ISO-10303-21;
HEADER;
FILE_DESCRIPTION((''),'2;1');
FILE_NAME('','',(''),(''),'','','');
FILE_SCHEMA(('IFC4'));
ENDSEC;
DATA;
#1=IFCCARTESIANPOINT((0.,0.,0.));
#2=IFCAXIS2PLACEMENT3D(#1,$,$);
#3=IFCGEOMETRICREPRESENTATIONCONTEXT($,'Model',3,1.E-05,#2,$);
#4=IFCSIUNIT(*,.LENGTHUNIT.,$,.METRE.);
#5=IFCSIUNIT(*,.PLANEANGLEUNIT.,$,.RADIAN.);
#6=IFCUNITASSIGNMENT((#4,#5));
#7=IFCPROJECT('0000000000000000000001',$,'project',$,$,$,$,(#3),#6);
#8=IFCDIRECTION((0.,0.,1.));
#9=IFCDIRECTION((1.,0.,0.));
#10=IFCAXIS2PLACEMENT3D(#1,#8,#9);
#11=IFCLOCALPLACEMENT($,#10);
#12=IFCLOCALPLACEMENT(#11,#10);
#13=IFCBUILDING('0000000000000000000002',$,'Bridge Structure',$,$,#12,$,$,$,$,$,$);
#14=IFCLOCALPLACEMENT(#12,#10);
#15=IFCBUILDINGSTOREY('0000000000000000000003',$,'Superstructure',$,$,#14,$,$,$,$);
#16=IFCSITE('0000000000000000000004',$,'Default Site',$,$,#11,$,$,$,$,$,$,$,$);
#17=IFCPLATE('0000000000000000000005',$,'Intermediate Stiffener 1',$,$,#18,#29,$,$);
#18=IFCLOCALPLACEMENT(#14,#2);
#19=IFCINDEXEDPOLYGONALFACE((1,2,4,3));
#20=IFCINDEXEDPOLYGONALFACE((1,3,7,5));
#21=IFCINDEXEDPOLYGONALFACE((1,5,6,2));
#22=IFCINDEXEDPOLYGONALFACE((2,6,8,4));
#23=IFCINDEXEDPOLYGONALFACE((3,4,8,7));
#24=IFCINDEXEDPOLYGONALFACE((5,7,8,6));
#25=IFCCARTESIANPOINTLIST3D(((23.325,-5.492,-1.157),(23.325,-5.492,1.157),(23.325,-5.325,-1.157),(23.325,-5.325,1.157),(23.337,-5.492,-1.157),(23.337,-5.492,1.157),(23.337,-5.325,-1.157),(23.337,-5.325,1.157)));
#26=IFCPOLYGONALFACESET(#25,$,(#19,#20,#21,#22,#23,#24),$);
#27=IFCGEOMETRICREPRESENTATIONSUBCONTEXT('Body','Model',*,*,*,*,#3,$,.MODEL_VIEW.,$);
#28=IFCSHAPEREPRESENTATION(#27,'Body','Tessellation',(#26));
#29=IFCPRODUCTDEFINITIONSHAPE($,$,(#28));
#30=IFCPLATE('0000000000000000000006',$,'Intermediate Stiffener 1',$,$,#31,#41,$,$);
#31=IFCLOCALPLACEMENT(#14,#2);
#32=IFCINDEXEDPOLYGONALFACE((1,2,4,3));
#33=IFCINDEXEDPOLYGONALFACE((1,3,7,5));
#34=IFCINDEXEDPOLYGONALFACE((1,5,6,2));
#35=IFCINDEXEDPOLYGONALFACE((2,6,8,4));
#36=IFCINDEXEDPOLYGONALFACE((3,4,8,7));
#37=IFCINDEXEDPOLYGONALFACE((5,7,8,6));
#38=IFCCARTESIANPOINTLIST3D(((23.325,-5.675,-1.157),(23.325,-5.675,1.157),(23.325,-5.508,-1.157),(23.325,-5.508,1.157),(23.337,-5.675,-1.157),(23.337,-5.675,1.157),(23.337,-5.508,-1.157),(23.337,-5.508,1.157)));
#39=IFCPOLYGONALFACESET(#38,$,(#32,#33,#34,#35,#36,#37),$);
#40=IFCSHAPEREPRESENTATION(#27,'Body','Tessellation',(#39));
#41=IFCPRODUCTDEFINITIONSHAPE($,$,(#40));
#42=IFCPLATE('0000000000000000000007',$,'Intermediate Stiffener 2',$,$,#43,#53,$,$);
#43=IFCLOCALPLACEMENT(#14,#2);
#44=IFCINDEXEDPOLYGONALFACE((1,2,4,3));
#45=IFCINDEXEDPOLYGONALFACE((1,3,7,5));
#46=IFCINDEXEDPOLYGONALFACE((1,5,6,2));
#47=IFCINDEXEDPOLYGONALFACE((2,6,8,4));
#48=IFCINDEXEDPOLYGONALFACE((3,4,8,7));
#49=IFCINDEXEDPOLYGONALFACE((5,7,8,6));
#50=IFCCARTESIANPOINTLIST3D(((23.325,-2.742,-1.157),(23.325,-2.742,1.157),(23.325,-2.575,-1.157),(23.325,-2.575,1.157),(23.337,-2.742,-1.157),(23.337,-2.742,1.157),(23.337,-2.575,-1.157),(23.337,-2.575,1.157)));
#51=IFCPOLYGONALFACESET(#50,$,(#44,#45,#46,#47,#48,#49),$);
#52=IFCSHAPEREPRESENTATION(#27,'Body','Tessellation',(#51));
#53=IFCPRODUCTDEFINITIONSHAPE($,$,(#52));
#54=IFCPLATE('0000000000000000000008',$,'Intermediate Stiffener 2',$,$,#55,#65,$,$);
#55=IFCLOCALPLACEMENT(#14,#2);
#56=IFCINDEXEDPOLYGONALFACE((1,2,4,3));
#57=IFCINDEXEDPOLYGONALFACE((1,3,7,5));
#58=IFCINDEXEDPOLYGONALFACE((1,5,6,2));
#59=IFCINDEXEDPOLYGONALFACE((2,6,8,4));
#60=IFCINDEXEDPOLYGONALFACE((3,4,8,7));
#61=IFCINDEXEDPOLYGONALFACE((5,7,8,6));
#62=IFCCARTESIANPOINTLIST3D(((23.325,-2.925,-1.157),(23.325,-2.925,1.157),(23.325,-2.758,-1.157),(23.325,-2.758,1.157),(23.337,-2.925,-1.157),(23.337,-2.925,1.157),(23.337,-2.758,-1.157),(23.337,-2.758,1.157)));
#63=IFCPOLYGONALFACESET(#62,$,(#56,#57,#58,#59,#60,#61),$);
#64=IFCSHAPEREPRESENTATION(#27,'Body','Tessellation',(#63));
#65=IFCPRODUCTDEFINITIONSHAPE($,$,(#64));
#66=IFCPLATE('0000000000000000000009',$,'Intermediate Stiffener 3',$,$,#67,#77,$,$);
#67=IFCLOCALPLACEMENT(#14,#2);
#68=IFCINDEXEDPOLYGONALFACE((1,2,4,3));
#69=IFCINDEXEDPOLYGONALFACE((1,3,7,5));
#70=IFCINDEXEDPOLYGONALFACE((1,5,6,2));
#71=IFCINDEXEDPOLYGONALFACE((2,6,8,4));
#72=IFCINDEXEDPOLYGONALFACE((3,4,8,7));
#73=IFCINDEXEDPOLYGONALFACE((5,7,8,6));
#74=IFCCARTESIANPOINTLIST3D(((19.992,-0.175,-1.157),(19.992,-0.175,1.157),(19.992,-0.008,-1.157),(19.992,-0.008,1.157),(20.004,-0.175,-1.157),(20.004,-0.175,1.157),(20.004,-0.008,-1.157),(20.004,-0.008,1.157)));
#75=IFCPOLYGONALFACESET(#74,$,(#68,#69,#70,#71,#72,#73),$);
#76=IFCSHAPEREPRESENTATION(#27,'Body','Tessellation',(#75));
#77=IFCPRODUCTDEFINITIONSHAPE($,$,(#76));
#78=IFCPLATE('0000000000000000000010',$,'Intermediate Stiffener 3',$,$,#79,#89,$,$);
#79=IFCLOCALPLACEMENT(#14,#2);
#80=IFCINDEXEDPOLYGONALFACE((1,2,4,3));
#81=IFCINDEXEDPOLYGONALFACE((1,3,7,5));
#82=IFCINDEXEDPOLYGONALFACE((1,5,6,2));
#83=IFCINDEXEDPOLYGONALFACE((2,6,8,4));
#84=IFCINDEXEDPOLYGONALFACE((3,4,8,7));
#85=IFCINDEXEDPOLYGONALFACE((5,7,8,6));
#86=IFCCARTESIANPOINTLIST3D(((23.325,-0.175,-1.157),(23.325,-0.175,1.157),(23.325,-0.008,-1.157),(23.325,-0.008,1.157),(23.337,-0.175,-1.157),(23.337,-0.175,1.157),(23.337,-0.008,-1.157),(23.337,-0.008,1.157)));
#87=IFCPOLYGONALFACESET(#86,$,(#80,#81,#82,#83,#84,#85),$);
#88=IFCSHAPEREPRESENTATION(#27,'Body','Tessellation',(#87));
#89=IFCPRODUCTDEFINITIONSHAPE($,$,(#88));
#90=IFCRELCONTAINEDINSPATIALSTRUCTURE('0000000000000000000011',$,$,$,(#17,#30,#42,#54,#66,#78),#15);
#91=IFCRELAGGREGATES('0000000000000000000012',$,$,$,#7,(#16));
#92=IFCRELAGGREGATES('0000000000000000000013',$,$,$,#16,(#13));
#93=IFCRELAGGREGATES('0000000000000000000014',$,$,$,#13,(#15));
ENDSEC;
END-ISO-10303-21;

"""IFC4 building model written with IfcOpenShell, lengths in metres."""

from ifc_helpers import new_model, si_unit, frame, origin, origin_with_axes, origin_2d_with_axis, place, context, subcontext, project, spatial, rectangle, extrude, element, save


model = new_model("IFC4")

# Units and contexts
model_context = context("Model", 3, precision=1e-05, world=origin())
body_context = subcontext(model_context, "Body", "Model", "MODEL_VIEW")
ifc_project = project(units=[si_unit("LENGTHUNIT", "METRE"), si_unit("PLANEANGLEUNIT", "RADIAN")], contexts=[model_context])

# Site, building, storey
site_placement = place(None, origin_with_axes())
site = spatial("IfcSite", under=ifc_project, at=site_placement, Name="Default Site")
building_placement = place(site_placement, origin_with_axes())
building = spatial("IfcBuilding", under=site, at=building_placement, Name="Bridge Structure")
storey_placement = place(building_placement, origin_with_axes())
storey = spatial("IfcBuildingStorey", under=building, at=storey_placement, Name="Superstructure")

# Plates
for number, where, z_axis, x_axis, name in (
    (1, (23.331, -5.4085, -1.157), (0.0, 0.0, 1.0), (1.0, 0.0, 0.0), "Intermediate Stiffener 1"),
    (2, (23.331, -5.5915, -1.157), (0.0, 0.0, 1.0), (1.0, 0.0, 0.0), "Intermediate Stiffener 1"),
    (3, (23.331, -2.6585, -1.157), (0.0, 0.0, 1.0), (1.0, 0.0, 0.0), "Intermediate Stiffener 2"),
    (4, (23.331, -2.8415, -1.157), (0.0, 0.0, 1.0), (1.0, 0.0, 0.0), "Intermediate Stiffener 2"),
    (5, (19.998, -0.0915, -1.157), (0.0, 0.0, 1.0), (1.0, 0.0, 0.0), "Intermediate Stiffener 3"),
    (6, (23.331, -0.0915, -1.157), (0.0, 0.0, 1.0), (1.0, 0.0, 0.0), "Intermediate Stiffener 3"),
):
    element("IfcPlate", number, at=place(storey_placement, frame(where, z_axis=z_axis, x_axis=x_axis)), inside=storey, Name=name, context=body_context, shape_type="SweptSolid", body=[
        extrude(rectangle(XDim=0.012, YDim=0.167, at=origin_2d_with_axis()), origin_with_axes(), (0.0, 0.0, 1.0), 2.314),
    ])

save(model, "model.ifc")
